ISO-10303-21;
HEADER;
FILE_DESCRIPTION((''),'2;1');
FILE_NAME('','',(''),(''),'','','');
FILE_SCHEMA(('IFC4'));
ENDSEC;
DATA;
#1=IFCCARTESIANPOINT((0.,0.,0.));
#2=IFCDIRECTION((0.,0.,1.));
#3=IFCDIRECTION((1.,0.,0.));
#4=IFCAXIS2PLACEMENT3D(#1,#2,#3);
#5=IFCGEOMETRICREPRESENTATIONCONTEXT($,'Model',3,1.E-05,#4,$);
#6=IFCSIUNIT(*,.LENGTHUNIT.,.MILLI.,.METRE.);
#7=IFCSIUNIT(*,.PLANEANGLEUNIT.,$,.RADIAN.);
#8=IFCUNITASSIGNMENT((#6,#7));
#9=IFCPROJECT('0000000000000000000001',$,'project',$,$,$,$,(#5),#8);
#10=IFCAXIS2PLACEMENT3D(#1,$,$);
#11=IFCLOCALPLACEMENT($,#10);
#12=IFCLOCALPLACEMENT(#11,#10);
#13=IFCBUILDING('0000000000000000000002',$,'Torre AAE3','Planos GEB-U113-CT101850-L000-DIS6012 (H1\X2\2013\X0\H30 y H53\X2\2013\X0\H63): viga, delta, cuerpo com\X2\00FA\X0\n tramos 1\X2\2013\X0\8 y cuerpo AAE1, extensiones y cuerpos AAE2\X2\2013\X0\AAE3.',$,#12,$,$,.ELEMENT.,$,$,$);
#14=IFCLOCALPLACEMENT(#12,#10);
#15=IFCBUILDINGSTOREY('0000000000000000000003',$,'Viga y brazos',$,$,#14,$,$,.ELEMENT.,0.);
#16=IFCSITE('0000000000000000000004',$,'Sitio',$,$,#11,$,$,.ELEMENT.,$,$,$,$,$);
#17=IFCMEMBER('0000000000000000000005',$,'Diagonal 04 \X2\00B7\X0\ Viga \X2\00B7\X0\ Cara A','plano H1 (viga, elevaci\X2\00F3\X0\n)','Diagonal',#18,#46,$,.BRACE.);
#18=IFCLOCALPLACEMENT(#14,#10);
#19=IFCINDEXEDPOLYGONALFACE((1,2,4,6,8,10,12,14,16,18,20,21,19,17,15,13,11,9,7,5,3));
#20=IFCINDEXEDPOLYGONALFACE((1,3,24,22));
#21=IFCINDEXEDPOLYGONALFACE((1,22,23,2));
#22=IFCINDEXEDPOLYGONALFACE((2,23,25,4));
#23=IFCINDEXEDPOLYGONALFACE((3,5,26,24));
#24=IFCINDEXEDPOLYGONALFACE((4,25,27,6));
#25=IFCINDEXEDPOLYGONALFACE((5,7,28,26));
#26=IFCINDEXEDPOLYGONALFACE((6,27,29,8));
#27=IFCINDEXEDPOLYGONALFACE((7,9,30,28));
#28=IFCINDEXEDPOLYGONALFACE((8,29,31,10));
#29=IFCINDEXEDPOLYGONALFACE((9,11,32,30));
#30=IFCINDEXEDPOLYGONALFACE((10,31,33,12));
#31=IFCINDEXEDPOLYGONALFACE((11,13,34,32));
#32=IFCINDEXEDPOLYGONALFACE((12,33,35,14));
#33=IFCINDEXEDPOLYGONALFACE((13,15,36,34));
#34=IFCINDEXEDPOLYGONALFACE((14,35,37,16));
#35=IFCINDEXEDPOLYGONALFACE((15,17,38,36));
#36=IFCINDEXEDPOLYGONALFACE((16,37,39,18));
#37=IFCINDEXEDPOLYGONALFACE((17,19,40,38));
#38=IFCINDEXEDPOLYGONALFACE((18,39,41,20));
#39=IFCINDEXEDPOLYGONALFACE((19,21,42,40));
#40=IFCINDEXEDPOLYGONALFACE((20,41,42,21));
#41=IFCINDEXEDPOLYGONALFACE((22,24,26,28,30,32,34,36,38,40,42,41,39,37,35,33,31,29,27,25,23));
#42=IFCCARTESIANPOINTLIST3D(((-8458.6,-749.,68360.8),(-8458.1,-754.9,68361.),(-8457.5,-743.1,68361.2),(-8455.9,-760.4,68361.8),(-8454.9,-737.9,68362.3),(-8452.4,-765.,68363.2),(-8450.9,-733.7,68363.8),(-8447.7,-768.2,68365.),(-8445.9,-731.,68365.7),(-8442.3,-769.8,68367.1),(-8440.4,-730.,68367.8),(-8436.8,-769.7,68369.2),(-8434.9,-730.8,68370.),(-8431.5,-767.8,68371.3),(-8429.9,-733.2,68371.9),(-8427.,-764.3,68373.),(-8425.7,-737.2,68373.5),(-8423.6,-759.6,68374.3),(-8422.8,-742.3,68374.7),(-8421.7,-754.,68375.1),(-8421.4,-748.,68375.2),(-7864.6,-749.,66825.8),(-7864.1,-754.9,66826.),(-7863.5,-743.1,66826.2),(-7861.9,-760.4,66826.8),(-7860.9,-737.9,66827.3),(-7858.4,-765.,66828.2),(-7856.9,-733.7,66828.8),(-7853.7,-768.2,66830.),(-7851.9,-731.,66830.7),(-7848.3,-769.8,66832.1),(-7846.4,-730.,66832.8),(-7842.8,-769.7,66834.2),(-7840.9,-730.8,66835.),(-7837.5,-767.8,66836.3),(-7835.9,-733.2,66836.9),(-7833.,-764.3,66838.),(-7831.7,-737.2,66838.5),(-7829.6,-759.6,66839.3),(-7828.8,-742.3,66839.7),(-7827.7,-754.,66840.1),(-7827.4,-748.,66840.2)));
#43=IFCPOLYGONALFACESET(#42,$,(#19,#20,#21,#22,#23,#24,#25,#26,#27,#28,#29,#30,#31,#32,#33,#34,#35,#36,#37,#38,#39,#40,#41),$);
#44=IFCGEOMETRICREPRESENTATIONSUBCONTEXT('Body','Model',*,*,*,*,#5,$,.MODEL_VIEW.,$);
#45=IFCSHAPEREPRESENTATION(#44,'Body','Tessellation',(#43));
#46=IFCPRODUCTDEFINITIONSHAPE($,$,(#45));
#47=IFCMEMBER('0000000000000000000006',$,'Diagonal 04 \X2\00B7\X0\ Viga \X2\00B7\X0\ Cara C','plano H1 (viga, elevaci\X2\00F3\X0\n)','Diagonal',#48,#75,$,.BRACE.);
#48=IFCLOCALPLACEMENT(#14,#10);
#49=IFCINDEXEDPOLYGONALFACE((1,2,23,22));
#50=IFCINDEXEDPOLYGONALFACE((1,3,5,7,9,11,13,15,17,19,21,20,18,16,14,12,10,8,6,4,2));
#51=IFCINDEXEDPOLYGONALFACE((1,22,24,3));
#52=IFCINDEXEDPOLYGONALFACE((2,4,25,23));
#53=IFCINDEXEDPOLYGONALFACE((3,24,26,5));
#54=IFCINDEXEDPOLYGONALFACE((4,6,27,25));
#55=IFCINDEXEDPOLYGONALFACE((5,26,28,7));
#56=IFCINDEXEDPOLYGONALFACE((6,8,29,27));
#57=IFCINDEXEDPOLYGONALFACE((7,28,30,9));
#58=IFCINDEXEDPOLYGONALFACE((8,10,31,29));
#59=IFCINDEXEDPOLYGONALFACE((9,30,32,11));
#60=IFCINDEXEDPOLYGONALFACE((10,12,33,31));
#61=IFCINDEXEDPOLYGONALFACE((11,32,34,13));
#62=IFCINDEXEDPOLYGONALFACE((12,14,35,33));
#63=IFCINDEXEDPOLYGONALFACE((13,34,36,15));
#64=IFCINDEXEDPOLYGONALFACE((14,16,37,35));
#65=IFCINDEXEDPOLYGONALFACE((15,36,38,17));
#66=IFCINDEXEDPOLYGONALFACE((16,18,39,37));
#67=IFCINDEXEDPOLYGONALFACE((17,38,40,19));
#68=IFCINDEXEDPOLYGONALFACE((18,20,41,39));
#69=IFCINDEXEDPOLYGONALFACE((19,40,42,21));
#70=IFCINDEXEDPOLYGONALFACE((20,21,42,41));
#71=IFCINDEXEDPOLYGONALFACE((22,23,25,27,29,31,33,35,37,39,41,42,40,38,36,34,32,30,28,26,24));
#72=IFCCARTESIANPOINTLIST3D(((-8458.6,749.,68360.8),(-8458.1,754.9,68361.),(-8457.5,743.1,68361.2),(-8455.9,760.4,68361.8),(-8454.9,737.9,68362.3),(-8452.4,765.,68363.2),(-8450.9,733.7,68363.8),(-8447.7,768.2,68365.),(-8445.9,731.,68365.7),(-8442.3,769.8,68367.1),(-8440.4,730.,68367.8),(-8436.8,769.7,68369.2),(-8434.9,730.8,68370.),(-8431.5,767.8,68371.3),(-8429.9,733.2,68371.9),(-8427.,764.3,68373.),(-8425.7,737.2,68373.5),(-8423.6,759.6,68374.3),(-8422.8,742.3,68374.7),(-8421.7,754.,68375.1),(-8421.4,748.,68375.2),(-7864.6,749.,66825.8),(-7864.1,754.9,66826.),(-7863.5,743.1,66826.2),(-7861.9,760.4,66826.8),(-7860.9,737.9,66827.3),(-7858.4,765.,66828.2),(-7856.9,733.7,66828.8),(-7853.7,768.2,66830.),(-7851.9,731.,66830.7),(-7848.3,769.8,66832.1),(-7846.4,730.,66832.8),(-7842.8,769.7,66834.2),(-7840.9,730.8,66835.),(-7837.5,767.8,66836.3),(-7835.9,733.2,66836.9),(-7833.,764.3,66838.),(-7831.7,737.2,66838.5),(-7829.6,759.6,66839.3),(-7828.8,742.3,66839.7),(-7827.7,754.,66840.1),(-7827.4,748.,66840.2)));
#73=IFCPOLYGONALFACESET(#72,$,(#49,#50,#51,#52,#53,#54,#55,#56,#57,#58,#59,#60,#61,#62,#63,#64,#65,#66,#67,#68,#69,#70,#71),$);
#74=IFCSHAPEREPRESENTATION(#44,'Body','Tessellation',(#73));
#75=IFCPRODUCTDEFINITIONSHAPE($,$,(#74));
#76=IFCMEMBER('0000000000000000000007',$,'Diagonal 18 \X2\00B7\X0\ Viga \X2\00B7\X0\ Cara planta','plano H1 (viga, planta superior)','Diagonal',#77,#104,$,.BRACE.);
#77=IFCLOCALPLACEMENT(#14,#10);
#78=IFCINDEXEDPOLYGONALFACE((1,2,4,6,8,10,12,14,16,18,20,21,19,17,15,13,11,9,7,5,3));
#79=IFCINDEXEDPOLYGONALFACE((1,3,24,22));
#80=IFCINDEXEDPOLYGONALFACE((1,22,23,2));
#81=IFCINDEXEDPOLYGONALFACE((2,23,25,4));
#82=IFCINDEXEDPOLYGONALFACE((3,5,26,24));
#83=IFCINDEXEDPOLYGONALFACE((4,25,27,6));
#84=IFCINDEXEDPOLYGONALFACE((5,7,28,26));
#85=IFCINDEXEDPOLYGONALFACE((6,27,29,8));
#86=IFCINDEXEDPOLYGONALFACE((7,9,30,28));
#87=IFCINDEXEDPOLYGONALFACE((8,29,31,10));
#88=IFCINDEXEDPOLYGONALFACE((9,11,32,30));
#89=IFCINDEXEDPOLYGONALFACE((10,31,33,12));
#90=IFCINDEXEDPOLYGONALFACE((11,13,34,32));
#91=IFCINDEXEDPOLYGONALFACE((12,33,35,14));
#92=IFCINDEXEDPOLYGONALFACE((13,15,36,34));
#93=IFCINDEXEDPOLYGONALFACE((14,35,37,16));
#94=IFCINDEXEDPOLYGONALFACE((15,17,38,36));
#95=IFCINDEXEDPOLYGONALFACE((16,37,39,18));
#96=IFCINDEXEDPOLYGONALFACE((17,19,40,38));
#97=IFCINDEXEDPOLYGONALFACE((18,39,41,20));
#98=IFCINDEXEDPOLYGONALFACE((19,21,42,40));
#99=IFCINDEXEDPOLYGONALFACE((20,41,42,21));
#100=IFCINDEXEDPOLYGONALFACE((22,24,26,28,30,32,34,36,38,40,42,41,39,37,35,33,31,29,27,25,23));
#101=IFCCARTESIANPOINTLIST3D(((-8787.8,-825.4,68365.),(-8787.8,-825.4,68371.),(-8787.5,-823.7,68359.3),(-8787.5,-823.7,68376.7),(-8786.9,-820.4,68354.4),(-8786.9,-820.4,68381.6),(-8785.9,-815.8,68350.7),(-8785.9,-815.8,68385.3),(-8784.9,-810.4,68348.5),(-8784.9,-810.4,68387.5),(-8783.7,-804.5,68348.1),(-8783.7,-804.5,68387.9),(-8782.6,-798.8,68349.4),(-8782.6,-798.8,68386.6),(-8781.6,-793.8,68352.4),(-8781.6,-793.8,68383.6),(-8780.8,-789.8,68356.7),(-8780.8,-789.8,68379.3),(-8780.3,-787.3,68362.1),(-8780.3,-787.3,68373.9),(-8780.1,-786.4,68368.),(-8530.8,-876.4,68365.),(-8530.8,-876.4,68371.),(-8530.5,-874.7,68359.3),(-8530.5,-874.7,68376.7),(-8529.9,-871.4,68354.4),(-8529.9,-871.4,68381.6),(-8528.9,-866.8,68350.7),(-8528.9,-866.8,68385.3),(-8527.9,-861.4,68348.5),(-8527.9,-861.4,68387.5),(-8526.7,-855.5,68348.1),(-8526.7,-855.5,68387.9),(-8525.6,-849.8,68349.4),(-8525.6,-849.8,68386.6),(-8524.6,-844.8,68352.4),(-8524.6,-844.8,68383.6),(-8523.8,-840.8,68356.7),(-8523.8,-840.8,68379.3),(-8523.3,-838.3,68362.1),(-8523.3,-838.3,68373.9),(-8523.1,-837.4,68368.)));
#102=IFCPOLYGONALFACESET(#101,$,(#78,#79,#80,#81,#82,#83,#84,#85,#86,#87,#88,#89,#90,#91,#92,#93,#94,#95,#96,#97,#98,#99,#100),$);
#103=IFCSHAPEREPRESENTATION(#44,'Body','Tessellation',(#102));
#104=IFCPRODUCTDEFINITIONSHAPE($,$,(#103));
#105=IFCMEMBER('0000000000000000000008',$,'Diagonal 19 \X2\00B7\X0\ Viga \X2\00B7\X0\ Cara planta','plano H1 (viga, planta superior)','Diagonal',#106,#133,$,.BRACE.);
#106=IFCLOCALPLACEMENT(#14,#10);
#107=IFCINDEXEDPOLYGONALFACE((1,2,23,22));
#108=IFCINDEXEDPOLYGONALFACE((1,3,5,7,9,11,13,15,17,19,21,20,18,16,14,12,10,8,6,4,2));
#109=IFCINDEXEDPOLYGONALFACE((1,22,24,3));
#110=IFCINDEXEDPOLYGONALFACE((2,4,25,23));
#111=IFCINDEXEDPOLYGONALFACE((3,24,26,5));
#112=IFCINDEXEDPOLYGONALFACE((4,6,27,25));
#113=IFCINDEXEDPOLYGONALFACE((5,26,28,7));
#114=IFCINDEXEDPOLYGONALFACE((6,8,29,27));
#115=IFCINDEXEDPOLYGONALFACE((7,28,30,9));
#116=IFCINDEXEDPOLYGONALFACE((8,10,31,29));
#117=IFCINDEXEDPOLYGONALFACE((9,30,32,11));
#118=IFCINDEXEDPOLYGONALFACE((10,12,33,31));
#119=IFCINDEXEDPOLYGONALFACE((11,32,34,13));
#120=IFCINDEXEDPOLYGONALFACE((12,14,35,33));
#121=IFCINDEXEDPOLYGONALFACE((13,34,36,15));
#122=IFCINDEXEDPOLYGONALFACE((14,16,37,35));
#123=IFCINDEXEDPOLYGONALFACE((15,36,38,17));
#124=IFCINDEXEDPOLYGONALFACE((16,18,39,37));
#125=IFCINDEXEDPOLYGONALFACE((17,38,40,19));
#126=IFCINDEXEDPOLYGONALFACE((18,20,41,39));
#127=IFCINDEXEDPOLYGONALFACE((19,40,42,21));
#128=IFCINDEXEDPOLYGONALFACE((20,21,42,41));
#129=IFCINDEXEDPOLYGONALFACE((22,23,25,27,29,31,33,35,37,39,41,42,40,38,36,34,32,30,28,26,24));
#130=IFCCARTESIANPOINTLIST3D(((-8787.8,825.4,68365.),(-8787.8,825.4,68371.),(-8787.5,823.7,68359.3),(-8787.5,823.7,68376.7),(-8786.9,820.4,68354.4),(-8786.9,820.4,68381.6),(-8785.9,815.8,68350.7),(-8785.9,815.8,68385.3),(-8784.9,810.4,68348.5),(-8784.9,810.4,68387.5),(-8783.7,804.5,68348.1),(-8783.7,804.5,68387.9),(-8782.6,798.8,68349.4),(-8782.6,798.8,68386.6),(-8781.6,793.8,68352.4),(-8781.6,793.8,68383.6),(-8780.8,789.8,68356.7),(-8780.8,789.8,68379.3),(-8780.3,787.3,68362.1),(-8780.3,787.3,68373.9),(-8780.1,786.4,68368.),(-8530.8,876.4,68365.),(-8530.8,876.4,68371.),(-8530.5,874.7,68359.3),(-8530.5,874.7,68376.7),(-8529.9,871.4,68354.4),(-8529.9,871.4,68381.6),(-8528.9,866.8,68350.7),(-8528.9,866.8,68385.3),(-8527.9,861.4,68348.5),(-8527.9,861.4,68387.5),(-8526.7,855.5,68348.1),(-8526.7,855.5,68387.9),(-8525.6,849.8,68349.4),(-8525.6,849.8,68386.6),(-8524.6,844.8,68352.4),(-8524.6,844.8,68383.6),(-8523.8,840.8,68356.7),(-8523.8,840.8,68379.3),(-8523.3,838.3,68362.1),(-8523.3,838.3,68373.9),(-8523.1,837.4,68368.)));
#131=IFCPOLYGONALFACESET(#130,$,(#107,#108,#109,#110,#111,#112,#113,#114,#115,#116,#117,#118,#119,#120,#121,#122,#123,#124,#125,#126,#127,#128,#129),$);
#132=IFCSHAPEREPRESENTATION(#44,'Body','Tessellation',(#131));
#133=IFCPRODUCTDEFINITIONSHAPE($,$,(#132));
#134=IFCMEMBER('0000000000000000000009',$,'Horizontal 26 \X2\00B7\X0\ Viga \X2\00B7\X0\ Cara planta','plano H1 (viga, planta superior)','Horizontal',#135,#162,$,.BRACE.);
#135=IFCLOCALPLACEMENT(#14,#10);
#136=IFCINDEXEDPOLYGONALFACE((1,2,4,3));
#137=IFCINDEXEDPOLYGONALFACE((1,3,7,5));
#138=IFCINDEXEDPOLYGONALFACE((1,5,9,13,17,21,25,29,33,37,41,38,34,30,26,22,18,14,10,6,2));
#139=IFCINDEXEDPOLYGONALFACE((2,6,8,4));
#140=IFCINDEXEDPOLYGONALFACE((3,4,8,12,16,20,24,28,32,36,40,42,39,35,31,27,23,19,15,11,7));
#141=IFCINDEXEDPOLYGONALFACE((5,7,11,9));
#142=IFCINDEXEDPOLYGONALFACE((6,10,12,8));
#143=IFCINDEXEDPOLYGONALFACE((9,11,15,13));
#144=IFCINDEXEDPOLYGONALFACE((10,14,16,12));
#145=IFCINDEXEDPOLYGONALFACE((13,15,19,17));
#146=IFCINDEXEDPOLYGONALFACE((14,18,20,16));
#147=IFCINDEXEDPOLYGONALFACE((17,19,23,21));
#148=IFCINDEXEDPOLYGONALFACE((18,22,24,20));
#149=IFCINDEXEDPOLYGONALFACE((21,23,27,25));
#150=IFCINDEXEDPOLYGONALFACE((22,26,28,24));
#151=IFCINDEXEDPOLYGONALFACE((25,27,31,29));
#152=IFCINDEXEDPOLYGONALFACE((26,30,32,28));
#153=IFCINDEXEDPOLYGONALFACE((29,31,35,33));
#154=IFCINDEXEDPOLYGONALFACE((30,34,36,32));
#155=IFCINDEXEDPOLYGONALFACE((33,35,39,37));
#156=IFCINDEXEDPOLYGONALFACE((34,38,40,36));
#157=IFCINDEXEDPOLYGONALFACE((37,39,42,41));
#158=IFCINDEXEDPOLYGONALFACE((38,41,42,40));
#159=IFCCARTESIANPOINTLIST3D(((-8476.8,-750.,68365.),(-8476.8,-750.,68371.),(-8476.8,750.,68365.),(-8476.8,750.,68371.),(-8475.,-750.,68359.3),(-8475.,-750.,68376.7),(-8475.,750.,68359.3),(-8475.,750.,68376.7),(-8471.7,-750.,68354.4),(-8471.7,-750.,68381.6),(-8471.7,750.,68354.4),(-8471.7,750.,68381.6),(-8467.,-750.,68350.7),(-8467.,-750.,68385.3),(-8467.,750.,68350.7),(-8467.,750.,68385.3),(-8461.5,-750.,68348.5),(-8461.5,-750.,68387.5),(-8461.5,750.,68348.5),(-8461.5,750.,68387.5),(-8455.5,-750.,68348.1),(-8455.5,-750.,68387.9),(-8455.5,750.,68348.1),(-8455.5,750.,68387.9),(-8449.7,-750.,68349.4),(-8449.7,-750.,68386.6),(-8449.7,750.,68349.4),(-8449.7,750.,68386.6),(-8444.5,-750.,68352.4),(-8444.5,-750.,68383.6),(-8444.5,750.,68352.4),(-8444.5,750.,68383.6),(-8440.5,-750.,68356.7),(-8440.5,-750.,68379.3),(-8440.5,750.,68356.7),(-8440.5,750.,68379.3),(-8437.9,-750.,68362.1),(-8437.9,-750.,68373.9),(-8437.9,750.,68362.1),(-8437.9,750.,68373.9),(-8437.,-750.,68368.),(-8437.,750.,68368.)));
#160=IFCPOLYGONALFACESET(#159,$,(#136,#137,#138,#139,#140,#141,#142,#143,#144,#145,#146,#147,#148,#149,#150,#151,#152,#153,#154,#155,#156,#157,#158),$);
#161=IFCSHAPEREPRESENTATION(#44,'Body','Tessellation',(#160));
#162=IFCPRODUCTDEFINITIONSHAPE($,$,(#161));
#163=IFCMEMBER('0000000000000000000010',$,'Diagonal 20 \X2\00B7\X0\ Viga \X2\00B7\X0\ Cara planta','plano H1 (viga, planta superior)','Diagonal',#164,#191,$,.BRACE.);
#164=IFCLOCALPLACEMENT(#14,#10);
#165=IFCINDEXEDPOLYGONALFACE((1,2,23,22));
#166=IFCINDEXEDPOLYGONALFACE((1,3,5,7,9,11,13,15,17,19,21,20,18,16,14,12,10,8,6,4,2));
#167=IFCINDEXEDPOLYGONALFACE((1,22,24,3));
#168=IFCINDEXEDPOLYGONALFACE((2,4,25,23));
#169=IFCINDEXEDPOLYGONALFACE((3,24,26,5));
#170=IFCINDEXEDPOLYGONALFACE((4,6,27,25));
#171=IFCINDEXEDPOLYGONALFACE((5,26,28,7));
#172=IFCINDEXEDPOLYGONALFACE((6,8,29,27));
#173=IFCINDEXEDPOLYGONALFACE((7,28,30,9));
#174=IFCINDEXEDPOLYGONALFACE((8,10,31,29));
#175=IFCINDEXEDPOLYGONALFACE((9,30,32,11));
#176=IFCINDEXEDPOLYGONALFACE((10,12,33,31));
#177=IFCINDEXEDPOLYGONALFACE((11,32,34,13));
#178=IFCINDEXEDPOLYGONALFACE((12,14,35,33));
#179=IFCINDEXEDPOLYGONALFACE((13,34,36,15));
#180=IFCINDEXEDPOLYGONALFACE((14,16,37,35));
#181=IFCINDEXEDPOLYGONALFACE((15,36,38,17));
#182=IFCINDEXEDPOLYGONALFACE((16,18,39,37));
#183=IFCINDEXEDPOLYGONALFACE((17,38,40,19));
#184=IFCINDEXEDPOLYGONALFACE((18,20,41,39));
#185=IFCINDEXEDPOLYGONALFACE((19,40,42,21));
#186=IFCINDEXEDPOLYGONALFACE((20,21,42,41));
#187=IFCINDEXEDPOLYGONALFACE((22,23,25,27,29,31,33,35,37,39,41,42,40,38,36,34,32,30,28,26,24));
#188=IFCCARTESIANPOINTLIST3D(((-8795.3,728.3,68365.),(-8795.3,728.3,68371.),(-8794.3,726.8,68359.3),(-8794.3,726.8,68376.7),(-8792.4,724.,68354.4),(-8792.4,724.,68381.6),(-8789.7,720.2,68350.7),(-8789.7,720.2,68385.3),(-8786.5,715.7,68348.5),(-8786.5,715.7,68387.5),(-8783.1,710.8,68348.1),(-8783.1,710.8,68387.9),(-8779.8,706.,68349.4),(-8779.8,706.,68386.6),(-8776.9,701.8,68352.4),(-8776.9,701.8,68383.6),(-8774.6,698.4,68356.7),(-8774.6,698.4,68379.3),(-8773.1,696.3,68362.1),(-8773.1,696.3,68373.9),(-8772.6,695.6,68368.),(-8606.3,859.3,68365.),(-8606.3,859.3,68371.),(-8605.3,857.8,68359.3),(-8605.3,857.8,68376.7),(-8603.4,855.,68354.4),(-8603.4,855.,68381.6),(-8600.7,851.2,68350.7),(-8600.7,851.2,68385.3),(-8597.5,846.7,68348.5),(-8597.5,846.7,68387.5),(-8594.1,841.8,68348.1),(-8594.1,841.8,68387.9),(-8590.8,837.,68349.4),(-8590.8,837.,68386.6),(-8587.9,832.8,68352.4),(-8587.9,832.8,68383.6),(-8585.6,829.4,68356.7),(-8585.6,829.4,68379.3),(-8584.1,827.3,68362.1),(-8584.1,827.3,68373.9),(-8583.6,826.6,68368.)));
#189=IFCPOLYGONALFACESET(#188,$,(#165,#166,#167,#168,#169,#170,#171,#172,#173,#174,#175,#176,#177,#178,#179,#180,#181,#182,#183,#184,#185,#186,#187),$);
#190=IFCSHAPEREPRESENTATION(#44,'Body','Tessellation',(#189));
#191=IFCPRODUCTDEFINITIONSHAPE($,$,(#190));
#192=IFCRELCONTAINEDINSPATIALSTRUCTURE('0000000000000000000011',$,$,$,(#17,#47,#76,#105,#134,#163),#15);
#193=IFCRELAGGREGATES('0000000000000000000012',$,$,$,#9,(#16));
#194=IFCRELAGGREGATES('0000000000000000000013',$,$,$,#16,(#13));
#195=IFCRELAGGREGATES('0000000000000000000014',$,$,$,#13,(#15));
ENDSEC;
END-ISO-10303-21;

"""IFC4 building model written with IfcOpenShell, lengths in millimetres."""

from ifc_helpers import new_model, si_unit, frame, origin, origin_with_axes, place, context, subcontext, project, spatial, circle, extrude, element, save


model = new_model("IFC4")

# Units and contexts
model_context = context("Model", 3, precision=1e-05, world=origin_with_axes())
body_context = subcontext(model_context, "Body", "Model", "MODEL_VIEW")
ifc_project = project(units=[si_unit("LENGTHUNIT", "METRE", prefix="MILLI"), si_unit("PLANEANGLEUNIT", "RADIAN")], contexts=[model_context])

# Site, building, storey
site_placement = place(None, origin())
site = spatial("IfcSite", under=ifc_project, at=site_placement, Name="Sitio", CompositionType="ELEMENT")
building_placement = place(site_placement, origin())
building = spatial("IfcBuilding", under=site, at=building_placement, Name="Torre AAE3", Description="Planos GEB-U113-CT101850-L000-DIS6012 (H1–H30 y H53–H63): viga, delta, cuerpo común tramos 1–8 y cuerpo AAE1, extensiones y cuerpos AAE2–AAE3.", CompositionType="ELEMENT")
storey_placement = place(building_placement, origin())
storey = spatial("IfcBuildingStorey", under=building, at=storey_placement, Name="Viga y brazos", CompositionType="ELEMENT", Elevation=0.0)

# Members
for number, where, z_axis, x_axis, name in (
    (1, (-8440.0, -750.0, 68368.0), (0.360892, 0.0, -0.932608), (0.928093, 0.098281, 0.359145), "Diagonal 04 · Viga · Cara A"),
    (2, (-8440.0, 750.0, 68368.0), (0.360892, 0.0, -0.932608), (0.928093, -0.098281, 0.359145), "Diagonal 04 · Viga · Cara C"),
):
    element("IfcMember", number, at=place(storey_placement, frame(where, z_axis=z_axis, x_axis=x_axis)), inside=storey, Name=name, Description="plano H1 (viga, elevación)", ObjectType="Diagonal", PredefinedType="BRACE", context=body_context, shape_type="SweptSolid", body=[
        extrude(circle(Radius=20.0), None, (0.0, 0.0, 1.0), 1645.9),
    ])
for number, where, z_axis, x_axis, name in (
    (3, (-8527.0, -857.0, 68368.0), (-0.980873, 0.194648, 0.0), (0.194648, 0.980873, 0.0), "Diagonal 18 · Viga · Cara planta"),
    (4, (-8784.0, 806.0, 68368.0), (0.980873, 0.194648, 0.0), (0.194648, -0.980873, 0.0), "Diagonal 19 · Viga · Cara planta"),
):
    element("IfcMember", number, at=place(storey_placement, frame(where, z_axis=z_axis, x_axis=x_axis)), inside=storey, Name=name, Description="plano H1 (viga, planta superior)", ObjectType="Diagonal", PredefinedType="BRACE", context=body_context, shape_type="SweptSolid", body=[
        extrude(circle(Radius=20.0), None, (0.0, 0.0, 1.0), 262.0),
    ])
member_1_placement = place(storey_placement, frame((-8457.0, 750.0, 68368.0), z_axis=(0.0, -1.0, 0.0), x_axis=(1.0, 0.0, 0.0)))
element("IfcMember", 5, at=member_1_placement, inside=storey, Name="Horizontal 26 · Viga · Cara planta", Description="plano H1 (viga, planta superior)", ObjectType="Horizontal", PredefinedType="BRACE", context=body_context, shape_type="SweptSolid", body=[
    extrude(circle(Radius=20.0), None, (0.0, 0.0, 1.0), 1500.0),
])
member_2_placement = place(storey_placement, frame((-8784.0, 712.0, 68368.0), z_axis=(0.821879, 0.569662, 0.0), x_axis=(0.569662, -0.821879, 0.0)))
element("IfcMember", 6, at=member_2_placement, inside=storey, Name="Diagonal 20 · Viga · Cara planta", Description="plano H1 (viga, planta superior)", ObjectType="Diagonal", PredefinedType="BRACE", context=body_context, shape_type="SweptSolid", body=[
    extrude(circle(Radius=20.0), None, (0.0, 0.0, 1.0), 230.0),
])

save(model, "model.ifc")
